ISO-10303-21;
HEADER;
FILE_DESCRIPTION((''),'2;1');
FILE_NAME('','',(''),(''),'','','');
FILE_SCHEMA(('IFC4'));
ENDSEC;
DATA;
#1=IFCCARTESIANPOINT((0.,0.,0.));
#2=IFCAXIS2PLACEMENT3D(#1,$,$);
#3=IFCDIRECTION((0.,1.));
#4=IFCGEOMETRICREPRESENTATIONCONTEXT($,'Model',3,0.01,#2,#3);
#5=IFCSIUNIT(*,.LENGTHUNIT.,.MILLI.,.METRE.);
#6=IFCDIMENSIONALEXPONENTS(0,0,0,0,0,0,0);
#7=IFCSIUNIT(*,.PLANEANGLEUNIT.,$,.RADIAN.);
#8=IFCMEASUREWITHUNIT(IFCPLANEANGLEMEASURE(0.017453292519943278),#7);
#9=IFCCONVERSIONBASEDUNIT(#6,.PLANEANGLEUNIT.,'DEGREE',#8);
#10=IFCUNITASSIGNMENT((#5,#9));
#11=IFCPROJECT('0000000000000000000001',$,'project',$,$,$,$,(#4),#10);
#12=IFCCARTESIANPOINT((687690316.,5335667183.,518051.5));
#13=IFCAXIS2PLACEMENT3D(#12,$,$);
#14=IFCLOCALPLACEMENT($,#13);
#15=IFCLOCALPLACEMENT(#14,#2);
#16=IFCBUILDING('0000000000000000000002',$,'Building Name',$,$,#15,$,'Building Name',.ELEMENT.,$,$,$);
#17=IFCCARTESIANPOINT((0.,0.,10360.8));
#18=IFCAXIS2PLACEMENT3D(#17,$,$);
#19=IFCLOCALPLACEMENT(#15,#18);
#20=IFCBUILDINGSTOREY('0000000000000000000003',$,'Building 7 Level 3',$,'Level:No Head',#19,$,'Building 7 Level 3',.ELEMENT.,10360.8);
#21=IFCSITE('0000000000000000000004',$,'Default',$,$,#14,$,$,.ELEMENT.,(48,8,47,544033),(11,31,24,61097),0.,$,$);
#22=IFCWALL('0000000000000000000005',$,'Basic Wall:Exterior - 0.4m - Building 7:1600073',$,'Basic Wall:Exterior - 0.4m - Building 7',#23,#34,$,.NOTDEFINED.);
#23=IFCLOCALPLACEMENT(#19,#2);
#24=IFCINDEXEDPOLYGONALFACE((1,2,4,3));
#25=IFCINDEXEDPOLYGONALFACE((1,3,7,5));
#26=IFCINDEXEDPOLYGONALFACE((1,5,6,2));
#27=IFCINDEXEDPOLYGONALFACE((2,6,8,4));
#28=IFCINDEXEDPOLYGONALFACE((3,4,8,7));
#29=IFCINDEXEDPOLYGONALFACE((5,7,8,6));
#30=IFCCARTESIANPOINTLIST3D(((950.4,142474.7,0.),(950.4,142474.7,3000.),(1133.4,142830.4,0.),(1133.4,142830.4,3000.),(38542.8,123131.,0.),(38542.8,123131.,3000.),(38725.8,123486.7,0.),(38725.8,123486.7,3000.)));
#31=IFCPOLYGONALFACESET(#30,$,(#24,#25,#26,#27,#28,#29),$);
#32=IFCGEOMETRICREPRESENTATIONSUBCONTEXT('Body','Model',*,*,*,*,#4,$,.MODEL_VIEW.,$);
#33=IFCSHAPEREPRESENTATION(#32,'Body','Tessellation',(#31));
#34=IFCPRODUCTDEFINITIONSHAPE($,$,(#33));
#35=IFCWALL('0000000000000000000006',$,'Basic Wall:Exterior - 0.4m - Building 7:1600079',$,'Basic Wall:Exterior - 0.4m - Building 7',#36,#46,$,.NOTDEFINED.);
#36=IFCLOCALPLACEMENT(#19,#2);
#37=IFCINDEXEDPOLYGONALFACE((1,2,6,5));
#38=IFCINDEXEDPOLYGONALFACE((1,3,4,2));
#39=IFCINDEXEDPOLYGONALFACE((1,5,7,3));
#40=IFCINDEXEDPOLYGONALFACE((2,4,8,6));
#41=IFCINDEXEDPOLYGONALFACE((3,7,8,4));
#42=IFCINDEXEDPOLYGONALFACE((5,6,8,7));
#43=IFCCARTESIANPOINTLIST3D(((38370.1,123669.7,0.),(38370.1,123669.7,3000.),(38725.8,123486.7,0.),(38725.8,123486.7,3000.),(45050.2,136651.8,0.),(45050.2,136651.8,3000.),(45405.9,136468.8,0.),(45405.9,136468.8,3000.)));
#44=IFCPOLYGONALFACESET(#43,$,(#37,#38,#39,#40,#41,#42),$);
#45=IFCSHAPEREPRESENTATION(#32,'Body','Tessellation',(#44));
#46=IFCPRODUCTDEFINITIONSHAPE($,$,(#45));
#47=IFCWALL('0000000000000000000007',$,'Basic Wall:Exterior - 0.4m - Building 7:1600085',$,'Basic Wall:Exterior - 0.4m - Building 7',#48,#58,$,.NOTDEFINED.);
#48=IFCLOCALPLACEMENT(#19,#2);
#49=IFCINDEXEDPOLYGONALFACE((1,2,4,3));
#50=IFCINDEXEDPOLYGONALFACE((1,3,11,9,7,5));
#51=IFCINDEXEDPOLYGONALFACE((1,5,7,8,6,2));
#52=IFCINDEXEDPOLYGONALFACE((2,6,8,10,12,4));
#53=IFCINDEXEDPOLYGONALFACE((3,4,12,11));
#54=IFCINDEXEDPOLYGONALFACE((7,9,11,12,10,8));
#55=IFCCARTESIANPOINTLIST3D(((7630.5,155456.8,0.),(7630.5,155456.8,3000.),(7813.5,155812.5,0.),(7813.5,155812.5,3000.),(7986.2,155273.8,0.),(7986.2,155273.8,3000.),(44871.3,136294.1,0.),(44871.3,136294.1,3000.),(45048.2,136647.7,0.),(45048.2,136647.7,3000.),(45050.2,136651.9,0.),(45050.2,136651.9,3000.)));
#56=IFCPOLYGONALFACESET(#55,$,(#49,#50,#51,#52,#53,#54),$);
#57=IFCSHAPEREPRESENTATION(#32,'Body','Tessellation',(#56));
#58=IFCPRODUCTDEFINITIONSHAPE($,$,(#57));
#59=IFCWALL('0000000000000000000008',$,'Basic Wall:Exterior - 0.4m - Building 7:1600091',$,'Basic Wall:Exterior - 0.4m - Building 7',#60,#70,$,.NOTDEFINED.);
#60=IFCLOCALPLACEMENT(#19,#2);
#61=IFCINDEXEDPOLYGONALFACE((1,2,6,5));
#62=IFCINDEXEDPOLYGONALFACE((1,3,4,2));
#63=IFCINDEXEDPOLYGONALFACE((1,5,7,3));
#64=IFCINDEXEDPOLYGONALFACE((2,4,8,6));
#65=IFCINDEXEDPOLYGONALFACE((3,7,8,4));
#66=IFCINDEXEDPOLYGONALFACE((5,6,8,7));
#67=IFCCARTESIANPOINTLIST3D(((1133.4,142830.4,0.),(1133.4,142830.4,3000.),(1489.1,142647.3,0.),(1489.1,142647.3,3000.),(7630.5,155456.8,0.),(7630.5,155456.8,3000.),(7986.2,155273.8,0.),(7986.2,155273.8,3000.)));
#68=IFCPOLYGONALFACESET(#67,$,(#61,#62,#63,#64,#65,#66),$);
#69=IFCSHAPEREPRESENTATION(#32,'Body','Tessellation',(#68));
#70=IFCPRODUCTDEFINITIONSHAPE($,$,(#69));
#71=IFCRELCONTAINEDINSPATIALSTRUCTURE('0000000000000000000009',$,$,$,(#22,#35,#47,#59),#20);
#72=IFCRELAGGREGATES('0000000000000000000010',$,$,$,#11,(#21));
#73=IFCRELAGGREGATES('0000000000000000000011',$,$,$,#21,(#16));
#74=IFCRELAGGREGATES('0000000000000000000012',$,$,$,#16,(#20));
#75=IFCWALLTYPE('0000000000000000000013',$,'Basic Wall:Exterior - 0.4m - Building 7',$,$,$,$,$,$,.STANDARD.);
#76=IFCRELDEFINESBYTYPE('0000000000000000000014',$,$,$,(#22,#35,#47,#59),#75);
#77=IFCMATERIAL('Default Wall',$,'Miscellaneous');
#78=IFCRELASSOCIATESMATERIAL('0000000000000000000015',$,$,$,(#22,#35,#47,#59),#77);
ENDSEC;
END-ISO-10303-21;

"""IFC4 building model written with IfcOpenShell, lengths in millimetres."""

from ifc_helpers import new_model, entity, si_unit, converted_unit, direction, frame, origin, place, context, subcontext, project, spatial, indexed_curve, outline, extrude, material, type_object, element, save


model = new_model("IFC4")

# Units and contexts
model_context = context("Model", 3, precision=0.01, world=origin(), true_north=direction((0.0, 1.0)))
body_context = subcontext(model_context, "Body", "Model", "MODEL_VIEW")
ifc_project = project(units=[si_unit("LENGTHUNIT", "METRE", prefix="MILLI"), converted_unit("PLANEANGLEUNIT", "DEGREE", entity("IfcPlaneAngleMeasure", 0.017453292519943278), si_unit("PLANEANGLEUNIT", "RADIAN"), dimensions=[0, 0, 0, 0, 0, 0, 0])], contexts=[model_context])

# Site, building, storey
site_placement = place(None, frame((687690316.0, 5335667183.0, 518051.5)))
site = spatial("IfcSite", under=ifc_project, at=site_placement, Name="Default", CompositionType="ELEMENT", RefLatitude=(48, 8, 47, 544033), RefLongitude=(11, 31, 24, 61097), RefElevation=0.0)
building_placement = place(site_placement, origin())
building = spatial("IfcBuilding", under=site, at=building_placement, Name="Building Name", LongName="Building Name", CompositionType="ELEMENT")
storey_placement = place(building_placement, frame((0.0, 0.0, 10360.8)))
storey = spatial("IfcBuildingStorey", under=building, at=storey_placement, Name="Building 7 Level 3", ObjectType="Level:No Head", LongName="Building 7 Level 3", CompositionType="ELEMENT", Elevation=10360.8)

# Walls
ifc_material_1 = material(Name="Default Wall", Category="Miscellaneous")
wall_type = type_object("IfcWallType", Name="Basic Wall:Exterior - 0.4m - Building 7", PredefinedType="STANDARD")
wall_1_placement = place(storey_placement, frame((1041.9, 142652.5, 0.0), z_axis=(0.0, 0.0, 1.0), x_axis=(0.889187, -0.457543, 0.0)))
element("IfcWall", 1, at=wall_1_placement, inside=storey, type_object=wall_type, material=ifc_material_1, Name="Basic Wall:Exterior - 0.4m - Building 7:1600073", ObjectType="Basic Wall:Exterior - 0.4m - Building 7", PredefinedType="NOTDEFINED", context=body_context, shape_type="SweptSolid", body=[
    extrude(outline(indexed_curve([(42277.2, 200.0), (0.0, 200.0), (0.0, -200.0), (42277.2, -200.0), (42277.2, 200.0)], self_intersect=False)), origin(), (0.0, 0.0, 1.0), 3000.0),
])
wall_2_placement = place(storey_placement, frame((38548.0, 123578.2, 0.0), z_axis=(0.0, 0.0, 1.0), x_axis=(0.457543, 0.889187, 0.0)))
element("IfcWall", 2, at=wall_2_placement, inside=storey, type_object=wall_type, material=ifc_material_1, Name="Basic Wall:Exterior - 0.4m - Building 7:1600079", ObjectType="Basic Wall:Exterior - 0.4m - Building 7", PredefinedType="NOTDEFINED", context=body_context, shape_type="SweptSolid", body=[
    extrude(outline(indexed_curve([(14600.0, 200.0), (0.0, 200.0), (0.0, -200.0), (14600.0, -200.0), (14600.0, 200.0)], self_intersect=False)), origin(), (0.0, 0.0, 1.0), 3000.0),
])
wall_3_placement = place(storey_placement, frame((44962.8, 136471.9, 0.0), z_axis=(0.0, 0.0, 1.0), x_axis=(-0.889187, 0.457543, 0.0)))
element("IfcWall", 3, at=wall_3_placement, inside=storey, type_object=wall_type, material=ifc_material_1, Name="Basic Wall:Exterior - 0.4m - Building 7:1600085", ObjectType="Basic Wall:Exterior - 0.4m - Building 7", PredefinedType="NOTDEFINED", context=body_context, shape_type="SweptSolid", body=[
    extrude(outline(indexed_curve([(41881.8, -200.0), (41881.8, 200.0), (41481.8, 200.0), (0.0, 200.0), (4.6, -195.4), (4.6, -200.0), (41881.8, -200.0)], self_intersect=False)), origin(), (0.0, 0.0, 1.0), 3000.0),
])
wall_4_placement = place(storey_placement, frame((7808.3, 155365.3, 0.0), z_axis=(0.0, 0.0, 1.0), x_axis=(-0.457543, -0.889187, 0.0)))
element("IfcWall", 4, at=wall_4_placement, inside=storey, type_object=wall_type, material=ifc_material_1, Name="Basic Wall:Exterior - 0.4m - Building 7:1600091", ObjectType="Basic Wall:Exterior - 0.4m - Building 7", PredefinedType="NOTDEFINED", context=body_context, shape_type="SweptSolid", body=[
    extrude(outline(indexed_curve([(14200.0, 200.0), (0.0, 200.0), (0.0, -200.0), (14200.0, -200.0), (14200.0, 200.0)], self_intersect=False)), origin(), (0.0, 0.0, 1.0), 3000.0),
])

save(model, "model.ifc")
